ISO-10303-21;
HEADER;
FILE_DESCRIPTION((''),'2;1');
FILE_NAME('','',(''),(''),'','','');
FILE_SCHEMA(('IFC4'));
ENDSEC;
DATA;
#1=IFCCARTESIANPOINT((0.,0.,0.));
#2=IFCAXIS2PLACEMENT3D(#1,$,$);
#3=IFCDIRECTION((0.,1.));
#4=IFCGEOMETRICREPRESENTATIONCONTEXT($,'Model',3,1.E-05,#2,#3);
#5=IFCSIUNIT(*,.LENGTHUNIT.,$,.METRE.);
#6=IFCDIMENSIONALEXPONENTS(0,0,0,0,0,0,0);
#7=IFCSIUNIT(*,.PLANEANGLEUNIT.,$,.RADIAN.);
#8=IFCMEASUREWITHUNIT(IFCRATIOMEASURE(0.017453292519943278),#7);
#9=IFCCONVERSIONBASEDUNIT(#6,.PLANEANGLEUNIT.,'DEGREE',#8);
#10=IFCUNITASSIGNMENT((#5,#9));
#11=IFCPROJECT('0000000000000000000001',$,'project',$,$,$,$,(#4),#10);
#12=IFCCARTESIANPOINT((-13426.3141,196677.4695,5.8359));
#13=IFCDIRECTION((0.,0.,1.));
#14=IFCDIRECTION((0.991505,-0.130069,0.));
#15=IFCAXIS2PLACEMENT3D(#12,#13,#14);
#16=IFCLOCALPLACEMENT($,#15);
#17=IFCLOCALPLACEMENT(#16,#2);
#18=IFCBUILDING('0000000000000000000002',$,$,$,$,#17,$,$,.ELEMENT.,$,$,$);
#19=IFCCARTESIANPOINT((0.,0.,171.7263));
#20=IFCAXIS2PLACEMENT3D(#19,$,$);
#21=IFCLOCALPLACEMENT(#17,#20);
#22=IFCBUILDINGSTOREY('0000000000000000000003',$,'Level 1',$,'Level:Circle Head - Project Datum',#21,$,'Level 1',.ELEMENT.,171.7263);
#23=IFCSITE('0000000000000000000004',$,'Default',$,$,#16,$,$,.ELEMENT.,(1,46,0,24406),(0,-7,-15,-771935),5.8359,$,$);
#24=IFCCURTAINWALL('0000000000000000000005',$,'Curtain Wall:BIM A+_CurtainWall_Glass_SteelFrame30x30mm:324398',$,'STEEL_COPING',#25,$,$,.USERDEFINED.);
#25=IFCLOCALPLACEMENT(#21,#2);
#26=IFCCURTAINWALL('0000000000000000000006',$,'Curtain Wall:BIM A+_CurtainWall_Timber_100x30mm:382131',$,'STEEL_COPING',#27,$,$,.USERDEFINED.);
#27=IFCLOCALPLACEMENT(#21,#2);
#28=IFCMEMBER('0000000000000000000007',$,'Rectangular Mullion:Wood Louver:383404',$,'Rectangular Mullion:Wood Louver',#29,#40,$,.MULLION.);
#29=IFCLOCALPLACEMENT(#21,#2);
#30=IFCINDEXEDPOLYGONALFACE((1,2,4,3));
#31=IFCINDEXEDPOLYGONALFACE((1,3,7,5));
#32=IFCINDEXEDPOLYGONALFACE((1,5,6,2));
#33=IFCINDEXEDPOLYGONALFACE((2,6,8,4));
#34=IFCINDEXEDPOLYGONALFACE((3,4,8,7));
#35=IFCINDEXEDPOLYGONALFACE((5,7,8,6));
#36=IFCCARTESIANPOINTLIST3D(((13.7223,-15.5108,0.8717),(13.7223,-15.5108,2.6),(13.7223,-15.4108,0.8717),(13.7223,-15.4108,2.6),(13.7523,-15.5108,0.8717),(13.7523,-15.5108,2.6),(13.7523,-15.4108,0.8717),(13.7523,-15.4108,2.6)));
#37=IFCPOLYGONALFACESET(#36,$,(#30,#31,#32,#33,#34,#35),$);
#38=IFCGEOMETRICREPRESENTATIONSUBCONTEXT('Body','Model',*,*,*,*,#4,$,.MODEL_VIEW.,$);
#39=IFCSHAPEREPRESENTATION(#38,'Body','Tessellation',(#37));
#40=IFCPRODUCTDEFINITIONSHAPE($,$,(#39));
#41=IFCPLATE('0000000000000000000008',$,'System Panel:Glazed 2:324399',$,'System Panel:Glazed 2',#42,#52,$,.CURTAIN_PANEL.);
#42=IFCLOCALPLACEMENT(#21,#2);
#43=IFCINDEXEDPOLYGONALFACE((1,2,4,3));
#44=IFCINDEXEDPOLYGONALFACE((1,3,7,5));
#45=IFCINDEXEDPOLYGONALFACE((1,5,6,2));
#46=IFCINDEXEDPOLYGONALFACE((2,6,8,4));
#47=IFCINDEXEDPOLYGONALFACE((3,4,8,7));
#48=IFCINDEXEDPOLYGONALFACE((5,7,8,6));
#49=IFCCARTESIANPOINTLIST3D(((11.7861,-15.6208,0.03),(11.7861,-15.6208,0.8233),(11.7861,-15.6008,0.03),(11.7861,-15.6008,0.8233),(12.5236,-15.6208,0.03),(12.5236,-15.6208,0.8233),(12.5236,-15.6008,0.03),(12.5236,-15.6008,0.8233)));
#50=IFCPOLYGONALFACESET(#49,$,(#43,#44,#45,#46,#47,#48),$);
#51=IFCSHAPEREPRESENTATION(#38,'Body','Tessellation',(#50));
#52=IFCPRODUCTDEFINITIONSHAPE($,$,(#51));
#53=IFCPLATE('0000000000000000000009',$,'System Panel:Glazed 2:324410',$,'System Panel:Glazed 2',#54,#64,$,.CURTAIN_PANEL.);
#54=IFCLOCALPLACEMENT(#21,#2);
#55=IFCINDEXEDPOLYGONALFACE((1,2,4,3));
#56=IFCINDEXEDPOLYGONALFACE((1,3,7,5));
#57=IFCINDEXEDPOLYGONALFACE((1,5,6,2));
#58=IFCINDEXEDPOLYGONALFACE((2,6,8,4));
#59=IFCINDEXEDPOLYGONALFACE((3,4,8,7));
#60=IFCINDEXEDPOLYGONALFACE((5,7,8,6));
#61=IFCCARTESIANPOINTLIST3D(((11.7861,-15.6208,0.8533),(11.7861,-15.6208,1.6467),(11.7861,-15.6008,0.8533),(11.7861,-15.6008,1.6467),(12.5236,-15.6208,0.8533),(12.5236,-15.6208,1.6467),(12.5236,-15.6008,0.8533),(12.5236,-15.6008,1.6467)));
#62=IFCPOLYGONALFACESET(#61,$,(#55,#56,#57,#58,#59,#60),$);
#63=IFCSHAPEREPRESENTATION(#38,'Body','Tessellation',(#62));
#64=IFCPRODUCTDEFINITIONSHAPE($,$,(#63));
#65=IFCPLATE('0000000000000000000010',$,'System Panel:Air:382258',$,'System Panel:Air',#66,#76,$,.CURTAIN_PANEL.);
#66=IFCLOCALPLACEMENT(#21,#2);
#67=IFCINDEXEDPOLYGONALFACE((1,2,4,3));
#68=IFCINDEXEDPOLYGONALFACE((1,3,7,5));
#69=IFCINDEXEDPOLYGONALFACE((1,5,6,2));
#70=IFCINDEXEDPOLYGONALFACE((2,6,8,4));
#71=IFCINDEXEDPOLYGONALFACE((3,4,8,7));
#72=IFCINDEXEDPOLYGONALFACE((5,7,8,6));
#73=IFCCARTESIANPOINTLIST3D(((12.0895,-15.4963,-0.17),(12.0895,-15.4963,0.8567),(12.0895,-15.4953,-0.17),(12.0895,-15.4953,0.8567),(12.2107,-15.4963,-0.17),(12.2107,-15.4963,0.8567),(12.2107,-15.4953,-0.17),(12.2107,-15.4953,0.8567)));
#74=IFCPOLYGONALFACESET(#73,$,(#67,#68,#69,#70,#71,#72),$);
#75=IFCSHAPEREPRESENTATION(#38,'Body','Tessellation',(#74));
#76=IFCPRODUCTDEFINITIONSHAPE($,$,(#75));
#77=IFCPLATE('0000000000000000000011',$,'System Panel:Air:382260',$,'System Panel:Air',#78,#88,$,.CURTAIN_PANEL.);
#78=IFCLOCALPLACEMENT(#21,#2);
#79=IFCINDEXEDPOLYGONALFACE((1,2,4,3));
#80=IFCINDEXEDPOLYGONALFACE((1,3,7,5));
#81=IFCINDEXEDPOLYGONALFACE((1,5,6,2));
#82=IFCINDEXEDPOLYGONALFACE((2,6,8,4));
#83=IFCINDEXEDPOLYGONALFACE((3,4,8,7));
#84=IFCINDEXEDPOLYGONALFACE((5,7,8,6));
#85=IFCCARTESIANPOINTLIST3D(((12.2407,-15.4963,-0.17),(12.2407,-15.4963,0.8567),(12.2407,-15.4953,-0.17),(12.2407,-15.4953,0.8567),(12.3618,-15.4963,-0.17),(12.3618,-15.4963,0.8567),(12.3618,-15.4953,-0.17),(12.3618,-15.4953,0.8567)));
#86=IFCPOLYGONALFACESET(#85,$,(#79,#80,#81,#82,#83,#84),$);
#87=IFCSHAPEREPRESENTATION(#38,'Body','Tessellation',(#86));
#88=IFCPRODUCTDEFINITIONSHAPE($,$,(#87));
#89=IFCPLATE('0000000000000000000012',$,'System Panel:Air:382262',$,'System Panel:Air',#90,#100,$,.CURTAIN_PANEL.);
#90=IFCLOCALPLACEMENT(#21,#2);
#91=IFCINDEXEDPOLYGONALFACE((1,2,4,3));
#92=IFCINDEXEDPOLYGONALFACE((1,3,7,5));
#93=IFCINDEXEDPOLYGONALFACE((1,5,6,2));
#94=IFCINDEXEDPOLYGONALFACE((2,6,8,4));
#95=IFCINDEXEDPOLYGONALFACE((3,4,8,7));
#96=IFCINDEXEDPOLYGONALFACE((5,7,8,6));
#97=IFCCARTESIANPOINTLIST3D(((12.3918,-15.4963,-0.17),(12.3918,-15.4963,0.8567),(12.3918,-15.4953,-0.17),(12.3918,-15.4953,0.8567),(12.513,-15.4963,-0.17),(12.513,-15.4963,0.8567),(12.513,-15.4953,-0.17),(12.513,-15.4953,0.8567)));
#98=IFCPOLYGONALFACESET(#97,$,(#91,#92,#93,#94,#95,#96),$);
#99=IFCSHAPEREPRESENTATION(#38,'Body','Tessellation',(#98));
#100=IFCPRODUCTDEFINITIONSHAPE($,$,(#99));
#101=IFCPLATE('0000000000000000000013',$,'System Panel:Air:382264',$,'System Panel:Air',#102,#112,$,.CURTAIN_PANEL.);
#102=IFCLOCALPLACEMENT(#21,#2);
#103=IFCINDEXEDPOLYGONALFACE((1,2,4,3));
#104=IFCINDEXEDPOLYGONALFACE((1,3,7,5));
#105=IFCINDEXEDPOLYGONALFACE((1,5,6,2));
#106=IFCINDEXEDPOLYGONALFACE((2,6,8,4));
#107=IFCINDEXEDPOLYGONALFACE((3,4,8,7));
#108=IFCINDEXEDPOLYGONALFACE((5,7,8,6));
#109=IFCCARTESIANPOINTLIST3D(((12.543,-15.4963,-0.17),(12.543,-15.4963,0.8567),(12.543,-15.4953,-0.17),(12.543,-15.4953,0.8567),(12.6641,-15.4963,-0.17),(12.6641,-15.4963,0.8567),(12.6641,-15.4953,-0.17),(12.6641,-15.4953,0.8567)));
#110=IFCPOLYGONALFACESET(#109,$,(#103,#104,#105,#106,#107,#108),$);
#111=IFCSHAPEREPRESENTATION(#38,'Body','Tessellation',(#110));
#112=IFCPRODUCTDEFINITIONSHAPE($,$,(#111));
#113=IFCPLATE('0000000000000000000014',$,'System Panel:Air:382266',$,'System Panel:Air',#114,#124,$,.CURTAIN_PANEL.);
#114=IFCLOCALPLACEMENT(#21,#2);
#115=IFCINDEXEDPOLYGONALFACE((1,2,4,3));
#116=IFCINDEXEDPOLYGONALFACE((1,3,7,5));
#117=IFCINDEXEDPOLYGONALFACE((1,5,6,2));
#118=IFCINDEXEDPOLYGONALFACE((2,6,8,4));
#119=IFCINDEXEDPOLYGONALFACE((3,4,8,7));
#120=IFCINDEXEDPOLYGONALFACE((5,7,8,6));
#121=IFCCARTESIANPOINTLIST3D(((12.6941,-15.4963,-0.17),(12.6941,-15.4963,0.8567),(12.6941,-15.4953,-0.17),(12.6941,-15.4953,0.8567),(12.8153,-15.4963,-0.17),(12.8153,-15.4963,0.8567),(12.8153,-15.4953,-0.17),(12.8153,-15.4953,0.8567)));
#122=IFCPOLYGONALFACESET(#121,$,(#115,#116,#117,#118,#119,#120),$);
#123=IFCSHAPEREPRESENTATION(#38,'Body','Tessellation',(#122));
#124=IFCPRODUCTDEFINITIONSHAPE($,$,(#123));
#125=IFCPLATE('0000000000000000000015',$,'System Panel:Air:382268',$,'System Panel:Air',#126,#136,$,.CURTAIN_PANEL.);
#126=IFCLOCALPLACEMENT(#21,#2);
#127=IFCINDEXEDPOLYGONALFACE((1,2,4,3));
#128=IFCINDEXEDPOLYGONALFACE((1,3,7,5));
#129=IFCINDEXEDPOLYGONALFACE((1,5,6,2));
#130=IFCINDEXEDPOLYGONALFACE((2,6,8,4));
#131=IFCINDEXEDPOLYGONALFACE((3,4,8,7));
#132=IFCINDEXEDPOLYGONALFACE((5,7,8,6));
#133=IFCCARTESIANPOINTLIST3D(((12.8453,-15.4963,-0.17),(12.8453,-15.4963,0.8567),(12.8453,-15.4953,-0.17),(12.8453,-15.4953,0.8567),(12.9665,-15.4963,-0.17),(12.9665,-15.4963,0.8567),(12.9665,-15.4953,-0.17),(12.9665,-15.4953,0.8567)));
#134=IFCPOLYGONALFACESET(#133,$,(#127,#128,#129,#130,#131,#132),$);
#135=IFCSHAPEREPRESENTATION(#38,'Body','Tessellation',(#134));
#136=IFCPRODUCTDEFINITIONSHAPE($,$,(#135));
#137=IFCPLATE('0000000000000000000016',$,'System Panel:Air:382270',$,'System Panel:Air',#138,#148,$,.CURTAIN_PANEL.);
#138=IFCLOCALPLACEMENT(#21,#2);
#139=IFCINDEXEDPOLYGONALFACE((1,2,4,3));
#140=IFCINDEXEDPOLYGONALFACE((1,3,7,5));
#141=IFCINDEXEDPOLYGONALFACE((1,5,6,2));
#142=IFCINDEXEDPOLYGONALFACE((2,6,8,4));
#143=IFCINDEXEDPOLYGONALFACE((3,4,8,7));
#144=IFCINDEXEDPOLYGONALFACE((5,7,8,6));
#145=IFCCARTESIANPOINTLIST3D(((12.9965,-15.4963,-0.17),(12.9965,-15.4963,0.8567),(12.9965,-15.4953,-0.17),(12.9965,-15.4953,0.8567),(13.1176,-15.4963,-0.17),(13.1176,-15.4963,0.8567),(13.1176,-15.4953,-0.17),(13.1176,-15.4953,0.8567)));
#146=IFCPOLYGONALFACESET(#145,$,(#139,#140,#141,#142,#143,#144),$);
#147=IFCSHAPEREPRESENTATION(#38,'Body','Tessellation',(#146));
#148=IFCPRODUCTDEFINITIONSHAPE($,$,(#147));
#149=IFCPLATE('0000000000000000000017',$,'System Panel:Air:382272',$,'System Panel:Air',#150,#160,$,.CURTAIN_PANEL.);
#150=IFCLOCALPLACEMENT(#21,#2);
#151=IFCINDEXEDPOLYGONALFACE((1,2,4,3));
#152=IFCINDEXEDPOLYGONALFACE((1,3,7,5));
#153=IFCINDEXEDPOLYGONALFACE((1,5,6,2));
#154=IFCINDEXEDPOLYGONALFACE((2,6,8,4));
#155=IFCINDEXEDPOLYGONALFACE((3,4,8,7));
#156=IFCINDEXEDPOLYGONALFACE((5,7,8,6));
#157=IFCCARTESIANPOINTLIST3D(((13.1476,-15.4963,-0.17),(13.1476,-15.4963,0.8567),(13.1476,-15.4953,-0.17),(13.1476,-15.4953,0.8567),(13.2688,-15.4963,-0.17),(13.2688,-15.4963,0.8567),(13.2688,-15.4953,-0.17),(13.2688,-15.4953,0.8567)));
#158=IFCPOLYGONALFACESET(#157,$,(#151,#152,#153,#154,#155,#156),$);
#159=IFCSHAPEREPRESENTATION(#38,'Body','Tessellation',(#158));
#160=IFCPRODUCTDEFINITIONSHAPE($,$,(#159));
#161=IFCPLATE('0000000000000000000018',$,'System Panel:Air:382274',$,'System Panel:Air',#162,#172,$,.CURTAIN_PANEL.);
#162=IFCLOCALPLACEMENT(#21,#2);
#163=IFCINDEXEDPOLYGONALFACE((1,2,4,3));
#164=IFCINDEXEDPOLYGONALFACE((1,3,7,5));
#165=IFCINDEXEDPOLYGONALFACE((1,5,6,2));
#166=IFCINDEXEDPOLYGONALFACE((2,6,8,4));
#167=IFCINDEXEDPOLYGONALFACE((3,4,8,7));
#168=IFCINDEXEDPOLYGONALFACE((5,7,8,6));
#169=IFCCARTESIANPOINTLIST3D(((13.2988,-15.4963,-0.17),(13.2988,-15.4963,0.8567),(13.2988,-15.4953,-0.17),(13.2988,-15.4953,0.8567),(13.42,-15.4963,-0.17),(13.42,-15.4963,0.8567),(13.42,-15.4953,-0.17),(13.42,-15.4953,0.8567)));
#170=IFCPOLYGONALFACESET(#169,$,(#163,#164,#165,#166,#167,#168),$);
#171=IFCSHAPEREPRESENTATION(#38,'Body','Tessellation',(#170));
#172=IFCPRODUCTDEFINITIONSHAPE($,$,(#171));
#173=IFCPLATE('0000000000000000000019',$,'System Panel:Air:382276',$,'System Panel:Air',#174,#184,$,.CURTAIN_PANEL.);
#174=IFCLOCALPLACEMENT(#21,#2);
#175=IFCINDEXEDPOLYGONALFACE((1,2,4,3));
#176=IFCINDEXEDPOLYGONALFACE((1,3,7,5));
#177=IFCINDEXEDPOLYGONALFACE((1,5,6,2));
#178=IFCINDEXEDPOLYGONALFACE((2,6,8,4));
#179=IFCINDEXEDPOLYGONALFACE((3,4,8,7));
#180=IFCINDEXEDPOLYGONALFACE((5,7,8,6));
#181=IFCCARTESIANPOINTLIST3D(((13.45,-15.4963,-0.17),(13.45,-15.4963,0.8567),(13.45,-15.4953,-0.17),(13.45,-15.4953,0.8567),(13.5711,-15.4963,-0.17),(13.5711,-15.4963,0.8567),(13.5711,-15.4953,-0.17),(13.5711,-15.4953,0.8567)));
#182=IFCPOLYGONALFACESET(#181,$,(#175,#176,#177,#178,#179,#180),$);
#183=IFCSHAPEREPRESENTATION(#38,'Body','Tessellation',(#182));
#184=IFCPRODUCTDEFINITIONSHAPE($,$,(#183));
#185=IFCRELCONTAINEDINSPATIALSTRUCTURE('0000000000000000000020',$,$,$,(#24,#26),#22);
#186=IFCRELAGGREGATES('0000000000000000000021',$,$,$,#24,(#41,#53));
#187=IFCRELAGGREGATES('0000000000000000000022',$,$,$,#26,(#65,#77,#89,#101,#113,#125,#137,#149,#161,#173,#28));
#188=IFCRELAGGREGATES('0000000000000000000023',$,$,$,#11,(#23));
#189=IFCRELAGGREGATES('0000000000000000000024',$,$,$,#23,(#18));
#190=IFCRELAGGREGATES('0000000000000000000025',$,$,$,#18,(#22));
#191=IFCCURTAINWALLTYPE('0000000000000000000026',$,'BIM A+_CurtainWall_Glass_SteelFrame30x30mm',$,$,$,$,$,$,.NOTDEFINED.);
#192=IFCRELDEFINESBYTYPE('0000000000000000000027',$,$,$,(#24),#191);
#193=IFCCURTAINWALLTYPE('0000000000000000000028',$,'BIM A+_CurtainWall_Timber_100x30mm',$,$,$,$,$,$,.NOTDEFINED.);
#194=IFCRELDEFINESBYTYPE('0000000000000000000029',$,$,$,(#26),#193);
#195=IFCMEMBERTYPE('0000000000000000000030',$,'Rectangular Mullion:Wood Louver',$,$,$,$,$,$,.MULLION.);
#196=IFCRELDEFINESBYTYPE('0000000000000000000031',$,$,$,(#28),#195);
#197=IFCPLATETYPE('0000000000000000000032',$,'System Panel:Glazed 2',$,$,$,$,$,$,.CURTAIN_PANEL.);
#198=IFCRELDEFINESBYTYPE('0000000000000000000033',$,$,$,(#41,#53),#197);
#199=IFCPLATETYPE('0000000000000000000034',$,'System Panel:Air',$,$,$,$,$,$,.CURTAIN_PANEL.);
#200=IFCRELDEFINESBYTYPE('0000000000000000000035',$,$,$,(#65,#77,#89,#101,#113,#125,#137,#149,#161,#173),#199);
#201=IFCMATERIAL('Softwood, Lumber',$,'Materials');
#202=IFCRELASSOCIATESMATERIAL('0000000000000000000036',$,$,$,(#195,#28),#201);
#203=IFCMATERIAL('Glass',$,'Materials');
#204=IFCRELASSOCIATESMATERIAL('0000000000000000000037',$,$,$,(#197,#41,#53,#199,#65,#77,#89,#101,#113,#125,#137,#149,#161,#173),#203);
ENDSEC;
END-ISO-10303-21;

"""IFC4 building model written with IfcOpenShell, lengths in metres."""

from ifc_helpers import new_model, entity, si_unit, converted_unit, direction, frame, origin, place, context, subcontext, project, spatial, indexed_curve, outline, extrude, source, transform, mapped, material, type_object, type_shapes, element, aggregate, save


model = new_model("IFC4")

# Units and contexts
model_context = context("Model", 3, precision=1e-05, world=origin(), true_north=direction((0.0, 1.0)))
body_context = subcontext(model_context, "Body", "Model", "MODEL_VIEW")
ifc_project = project(units=[si_unit("LENGTHUNIT", "METRE"), converted_unit("PLANEANGLEUNIT", "DEGREE", entity("IfcRatioMeasure", 0.017453292519943278), si_unit("PLANEANGLEUNIT", "RADIAN"), dimensions=[0, 0, 0, 0, 0, 0, 0])], contexts=[model_context])

# Site, building, storey
site_placement = place(None, frame((-13426.3141, 196677.4695, 5.8359), z_axis=(0.0, 0.0, 1.0), x_axis=(0.991505, -0.130069, 0.0)))
site = spatial("IfcSite", under=ifc_project, at=site_placement, Name="Default", CompositionType="ELEMENT", RefLatitude=(1, 46, 0, 24406), RefLongitude=(0, -7, -15, -771935), RefElevation=5.8359)
building_placement = place(site_placement, origin())
building = spatial("IfcBuilding", under=site, at=building_placement, CompositionType="ELEMENT")
storey_placement = place(building_placement, frame((0.0, 0.0, 171.7263)))
storey = spatial("IfcBuildingStorey", under=building, at=storey_placement, Name="Level 1", ObjectType="Level:Circle Head - Project Datum", LongName="Level 1", CompositionType="ELEMENT", Elevation=171.7263)

# Curtain wall
curtain_wall_type_1 = type_object("IfcCurtainWallType", Name="BIM A+_CurtainWall_Glass_SteelFrame30x30mm", PredefinedType="NOTDEFINED")
curtain_wall_1_placement = place(storey_placement, frame((0.0, 0.0, -171.7263)))
curtain_wall_1 = element("IfcCurtainWall", 1, at=curtain_wall_1_placement, inside=storey, type_object=curtain_wall_type_1, Name="Curtain Wall:BIM A+_CurtainWall_Glass_SteelFrame30x30mm:324398", ObjectType="STEEL_COPING", PredefinedType="USERDEFINED")

# Curtain wall, member
curtain_wall_type_2 = type_object("IfcCurtainWallType", Name="BIM A+_CurtainWall_Timber_100x30mm", PredefinedType="NOTDEFINED")
curtain_wall_2_placement = place(storey_placement, frame((0.0, 0.0, -171.7263)))
curtain_wall_2 = element("IfcCurtainWall", 2, at=curtain_wall_2_placement, inside=storey, type_object=curtain_wall_type_2, Name="Curtain Wall:BIM A+_CurtainWall_Timber_100x30mm:382131", ObjectType="STEEL_COPING", PredefinedType="USERDEFINED")
ifc_material_1 = material(Name="Softwood, Lumber", Category="Materials")
member_type_1 = type_object("IfcMemberType", Name="Rectangular Mullion:Wood Louver", PredefinedType="MULLION", material=ifc_material_1)
shared_shape_1 = source(origin(), body_context, "Body", "SweptSolid", [
    extrude(outline(indexed_curve([(-0.05, -0.015), (0.05, -0.015), (0.05, 0.015), (-0.05, 0.015), (-0.05, -0.015)], self_intersect=False)), frame((0.0, -0.035, -1.7283), z_axis=(0.0, 0.0, 1.0), x_axis=(0.0, -1.0, 0.0)), (0.0, 0.0, 1.0), 1.7283),
])
type_shapes(member_type_1, [shared_shape_1])
member_1_placement = place(curtain_wall_2_placement, frame((13.7373, -15.4958, 172.598), z_axis=(0.0, 0.0, -1.0), x_axis=(1.0, 0.0, 0.0)))
member_1 = element("IfcMember", 3, at=member_1_placement, type_object=member_type_1, material=ifc_material_1, Name="Rectangular Mullion:Wood Louver:383404", ObjectType="Rectangular Mullion:Wood Louver", PredefinedType="MULLION", context=body_context, shape_type="MappedRepresentation", body=[
    mapped(shared_shape_1, transform((0.0, 0.0, 0.0), scale=1.0)),
])

# Plates
ifc_material_2 = material(Name="Glass", Category="Materials")
plate_type_1 = type_object("IfcPlateType", Name="System Panel:Glazed 2", PredefinedType="CURTAIN_PANEL", material=ifc_material_2)
shared_shape_2 = source(origin(), body_context, "Body", "SweptSolid", [
    extrude(outline(indexed_curve([(-0.01, -0.3688), (0.01, -0.3688), (0.01, 0.3688), (-0.01, 0.3688), (-0.01, -0.3688)], self_intersect=False)), frame((0.0, 0.0, 0.0), z_axis=(0.0, 0.0, 1.0), x_axis=(0.0, 1.0, 0.0)), (0.0, 0.0, 1.0), 0.7933),
])
type_shapes(plate_type_1, [shared_shape_2])
plate_1_placement = place(curtain_wall_1_placement, frame((12.1548, -15.6108, 171.7563), z_axis=(0.0, 0.0, 1.0), x_axis=(-1.0, 0.0, 0.0)))
plate_1 = element("IfcPlate", 4, at=plate_1_placement, type_object=plate_type_1, material=ifc_material_2, Name="System Panel:Glazed 2:324399", ObjectType="System Panel:Glazed 2", PredefinedType="CURTAIN_PANEL", context=body_context, shape_type="MappedRepresentation", body=[
    mapped(shared_shape_2, transform((0.0, 0.0, 0.0), scale=1.0)),
])
plate_2_placement = place(curtain_wall_1_placement, frame((12.1548, -15.6108, 172.5796), z_axis=(0.0, 0.0, 1.0), x_axis=(-1.0, 0.0, 0.0)))
plate_2 = element("IfcPlate", 5, at=plate_2_placement, type_object=plate_type_1, material=ifc_material_2, Name="System Panel:Glazed 2:324410", ObjectType="System Panel:Glazed 2", PredefinedType="CURTAIN_PANEL", context=body_context, shape_type="MappedRepresentation", body=[
    mapped(shared_shape_2, transform((0.0, 0.0, 0.0), scale=1.0)),
])
aggregate(curtain_wall_1, [plate_1, plate_2])
plate_type_2 = type_object("IfcPlateType", Name="System Panel:Air", PredefinedType="CURTAIN_PANEL", material=ifc_material_2)
shared_shape_3 = source(origin(), body_context, "Body", "SweptSolid", [
    extrude(outline(indexed_curve([(-0.0005, -0.0606), (0.0005, -0.0606), (0.0005, 0.0606), (-0.0005, 0.0606), (-0.0005, -0.0606)], self_intersect=False)), frame((0.0, 0.0, 0.0), z_axis=(0.0, 0.0, 1.0), x_axis=(0.0, 1.0, 0.0)), (0.0, 0.0, 1.0), 1.0267),
])
type_shapes(plate_type_2, [shared_shape_3])
plate_3_placement = place(curtain_wall_2_placement, frame((12.1501, -15.4958, 171.5563)))
plate_3 = element("IfcPlate", 6, at=plate_3_placement, type_object=plate_type_2, material=ifc_material_2, Name="System Panel:Air:382258", ObjectType="System Panel:Air", PredefinedType="CURTAIN_PANEL", context=body_context, shape_type="MappedRepresentation", body=[
    mapped(shared_shape_3, transform((0.0, 0.0, 0.0), scale=1.0)),
])
plate_4_placement = place(curtain_wall_2_placement, frame((12.3012, -15.4958, 171.5563)))
plate_4 = element("IfcPlate", 7, at=plate_4_placement, type_object=plate_type_2, material=ifc_material_2, Name="System Panel:Air:382260", ObjectType="System Panel:Air", PredefinedType="CURTAIN_PANEL", context=body_context, shape_type="MappedRepresentation", body=[
    mapped(shared_shape_3, transform((0.0, 0.0, 0.0), scale=1.0)),
])
plate_5_placement = place(curtain_wall_2_placement, frame((12.4524, -15.4958, 171.5563)))
plate_5 = element("IfcPlate", 8, at=plate_5_placement, type_object=plate_type_2, material=ifc_material_2, Name="System Panel:Air:382262", ObjectType="System Panel:Air", PredefinedType="CURTAIN_PANEL", context=body_context, shape_type="MappedRepresentation", body=[
    mapped(shared_shape_3, transform((0.0, 0.0, 0.0), scale=1.0)),
])
plate_6_placement = place(curtain_wall_2_placement, frame((12.6036, -15.4958, 171.5563)))
plate_6 = element("IfcPlate", 9, at=plate_6_placement, type_object=plate_type_2, material=ifc_material_2, Name="System Panel:Air:382264", ObjectType="System Panel:Air", PredefinedType="CURTAIN_PANEL", context=body_context, shape_type="MappedRepresentation", body=[
    mapped(shared_shape_3, transform((0.0, 0.0, 0.0), scale=1.0)),
])
plate_7_placement = place(curtain_wall_2_placement, frame((12.7547, -15.4958, 171.5563)))
plate_7 = element("IfcPlate", 10, at=plate_7_placement, type_object=plate_type_2, material=ifc_material_2, Name="System Panel:Air:382266", ObjectType="System Panel:Air", PredefinedType="CURTAIN_PANEL", context=body_context, shape_type="MappedRepresentation", body=[
    mapped(shared_shape_3, transform((0.0, 0.0, 0.0), scale=1.0)),
])
plate_8_placement = place(curtain_wall_2_placement, frame((12.9059, -15.4958, 171.5563)))
plate_8 = element("IfcPlate", 11, at=plate_8_placement, type_object=plate_type_2, material=ifc_material_2, Name="System Panel:Air:382268", ObjectType="System Panel:Air", PredefinedType="CURTAIN_PANEL", context=body_context, shape_type="MappedRepresentation", body=[
    mapped(shared_shape_3, transform((0.0, 0.0, 0.0), scale=1.0)),
])
plate_9_placement = place(curtain_wall_2_placement, frame((13.057, -15.4958, 171.5563)))
plate_9 = element("IfcPlate", 12, at=plate_9_placement, type_object=plate_type_2, material=ifc_material_2, Name="System Panel:Air:382270", ObjectType="System Panel:Air", PredefinedType="CURTAIN_PANEL", context=body_context, shape_type="MappedRepresentation", body=[
    mapped(shared_shape_3, transform((0.0, 0.0, 0.0), scale=1.0)),
])
plate_10_placement = place(curtain_wall_2_placement, frame((13.2082, -15.4958, 171.5563)))
plate_10 = element("IfcPlate", 13, at=plate_10_placement, type_object=plate_type_2, material=ifc_material_2, Name="System Panel:Air:382272", ObjectType="System Panel:Air", PredefinedType="CURTAIN_PANEL", context=body_context, shape_type="MappedRepresentation", body=[
    mapped(shared_shape_3, transform((0.0, 0.0, 0.0), scale=1.0)),
])
plate_11_placement = place(curtain_wall_2_placement, frame((13.3594, -15.4958, 171.5563)))
plate_11 = element("IfcPlate", 14, at=plate_11_placement, type_object=plate_type_2, material=ifc_material_2, Name="System Panel:Air:382274", ObjectType="System Panel:Air", PredefinedType="CURTAIN_PANEL", context=body_context, shape_type="MappedRepresentation", body=[
    mapped(shared_shape_3, transform((0.0, 0.0, 0.0), scale=1.0)),
])
plate_12_placement = place(curtain_wall_2_placement, frame((13.5105, -15.4958, 171.5563)))
plate_12 = element("IfcPlate", 15, at=plate_12_placement, type_object=plate_type_2, material=ifc_material_2, Name="System Panel:Air:382276", ObjectType="System Panel:Air", PredefinedType="CURTAIN_PANEL", context=body_context, shape_type="MappedRepresentation", body=[
    mapped(shared_shape_3, transform((0.0, 0.0, 0.0), scale=1.0)),
])
aggregate(curtain_wall_2, [plate_3, plate_4, plate_5, plate_6, plate_7, plate_8, plate_9, plate_10, plate_11, plate_12, member_1])

save(model, "model.ifc")
